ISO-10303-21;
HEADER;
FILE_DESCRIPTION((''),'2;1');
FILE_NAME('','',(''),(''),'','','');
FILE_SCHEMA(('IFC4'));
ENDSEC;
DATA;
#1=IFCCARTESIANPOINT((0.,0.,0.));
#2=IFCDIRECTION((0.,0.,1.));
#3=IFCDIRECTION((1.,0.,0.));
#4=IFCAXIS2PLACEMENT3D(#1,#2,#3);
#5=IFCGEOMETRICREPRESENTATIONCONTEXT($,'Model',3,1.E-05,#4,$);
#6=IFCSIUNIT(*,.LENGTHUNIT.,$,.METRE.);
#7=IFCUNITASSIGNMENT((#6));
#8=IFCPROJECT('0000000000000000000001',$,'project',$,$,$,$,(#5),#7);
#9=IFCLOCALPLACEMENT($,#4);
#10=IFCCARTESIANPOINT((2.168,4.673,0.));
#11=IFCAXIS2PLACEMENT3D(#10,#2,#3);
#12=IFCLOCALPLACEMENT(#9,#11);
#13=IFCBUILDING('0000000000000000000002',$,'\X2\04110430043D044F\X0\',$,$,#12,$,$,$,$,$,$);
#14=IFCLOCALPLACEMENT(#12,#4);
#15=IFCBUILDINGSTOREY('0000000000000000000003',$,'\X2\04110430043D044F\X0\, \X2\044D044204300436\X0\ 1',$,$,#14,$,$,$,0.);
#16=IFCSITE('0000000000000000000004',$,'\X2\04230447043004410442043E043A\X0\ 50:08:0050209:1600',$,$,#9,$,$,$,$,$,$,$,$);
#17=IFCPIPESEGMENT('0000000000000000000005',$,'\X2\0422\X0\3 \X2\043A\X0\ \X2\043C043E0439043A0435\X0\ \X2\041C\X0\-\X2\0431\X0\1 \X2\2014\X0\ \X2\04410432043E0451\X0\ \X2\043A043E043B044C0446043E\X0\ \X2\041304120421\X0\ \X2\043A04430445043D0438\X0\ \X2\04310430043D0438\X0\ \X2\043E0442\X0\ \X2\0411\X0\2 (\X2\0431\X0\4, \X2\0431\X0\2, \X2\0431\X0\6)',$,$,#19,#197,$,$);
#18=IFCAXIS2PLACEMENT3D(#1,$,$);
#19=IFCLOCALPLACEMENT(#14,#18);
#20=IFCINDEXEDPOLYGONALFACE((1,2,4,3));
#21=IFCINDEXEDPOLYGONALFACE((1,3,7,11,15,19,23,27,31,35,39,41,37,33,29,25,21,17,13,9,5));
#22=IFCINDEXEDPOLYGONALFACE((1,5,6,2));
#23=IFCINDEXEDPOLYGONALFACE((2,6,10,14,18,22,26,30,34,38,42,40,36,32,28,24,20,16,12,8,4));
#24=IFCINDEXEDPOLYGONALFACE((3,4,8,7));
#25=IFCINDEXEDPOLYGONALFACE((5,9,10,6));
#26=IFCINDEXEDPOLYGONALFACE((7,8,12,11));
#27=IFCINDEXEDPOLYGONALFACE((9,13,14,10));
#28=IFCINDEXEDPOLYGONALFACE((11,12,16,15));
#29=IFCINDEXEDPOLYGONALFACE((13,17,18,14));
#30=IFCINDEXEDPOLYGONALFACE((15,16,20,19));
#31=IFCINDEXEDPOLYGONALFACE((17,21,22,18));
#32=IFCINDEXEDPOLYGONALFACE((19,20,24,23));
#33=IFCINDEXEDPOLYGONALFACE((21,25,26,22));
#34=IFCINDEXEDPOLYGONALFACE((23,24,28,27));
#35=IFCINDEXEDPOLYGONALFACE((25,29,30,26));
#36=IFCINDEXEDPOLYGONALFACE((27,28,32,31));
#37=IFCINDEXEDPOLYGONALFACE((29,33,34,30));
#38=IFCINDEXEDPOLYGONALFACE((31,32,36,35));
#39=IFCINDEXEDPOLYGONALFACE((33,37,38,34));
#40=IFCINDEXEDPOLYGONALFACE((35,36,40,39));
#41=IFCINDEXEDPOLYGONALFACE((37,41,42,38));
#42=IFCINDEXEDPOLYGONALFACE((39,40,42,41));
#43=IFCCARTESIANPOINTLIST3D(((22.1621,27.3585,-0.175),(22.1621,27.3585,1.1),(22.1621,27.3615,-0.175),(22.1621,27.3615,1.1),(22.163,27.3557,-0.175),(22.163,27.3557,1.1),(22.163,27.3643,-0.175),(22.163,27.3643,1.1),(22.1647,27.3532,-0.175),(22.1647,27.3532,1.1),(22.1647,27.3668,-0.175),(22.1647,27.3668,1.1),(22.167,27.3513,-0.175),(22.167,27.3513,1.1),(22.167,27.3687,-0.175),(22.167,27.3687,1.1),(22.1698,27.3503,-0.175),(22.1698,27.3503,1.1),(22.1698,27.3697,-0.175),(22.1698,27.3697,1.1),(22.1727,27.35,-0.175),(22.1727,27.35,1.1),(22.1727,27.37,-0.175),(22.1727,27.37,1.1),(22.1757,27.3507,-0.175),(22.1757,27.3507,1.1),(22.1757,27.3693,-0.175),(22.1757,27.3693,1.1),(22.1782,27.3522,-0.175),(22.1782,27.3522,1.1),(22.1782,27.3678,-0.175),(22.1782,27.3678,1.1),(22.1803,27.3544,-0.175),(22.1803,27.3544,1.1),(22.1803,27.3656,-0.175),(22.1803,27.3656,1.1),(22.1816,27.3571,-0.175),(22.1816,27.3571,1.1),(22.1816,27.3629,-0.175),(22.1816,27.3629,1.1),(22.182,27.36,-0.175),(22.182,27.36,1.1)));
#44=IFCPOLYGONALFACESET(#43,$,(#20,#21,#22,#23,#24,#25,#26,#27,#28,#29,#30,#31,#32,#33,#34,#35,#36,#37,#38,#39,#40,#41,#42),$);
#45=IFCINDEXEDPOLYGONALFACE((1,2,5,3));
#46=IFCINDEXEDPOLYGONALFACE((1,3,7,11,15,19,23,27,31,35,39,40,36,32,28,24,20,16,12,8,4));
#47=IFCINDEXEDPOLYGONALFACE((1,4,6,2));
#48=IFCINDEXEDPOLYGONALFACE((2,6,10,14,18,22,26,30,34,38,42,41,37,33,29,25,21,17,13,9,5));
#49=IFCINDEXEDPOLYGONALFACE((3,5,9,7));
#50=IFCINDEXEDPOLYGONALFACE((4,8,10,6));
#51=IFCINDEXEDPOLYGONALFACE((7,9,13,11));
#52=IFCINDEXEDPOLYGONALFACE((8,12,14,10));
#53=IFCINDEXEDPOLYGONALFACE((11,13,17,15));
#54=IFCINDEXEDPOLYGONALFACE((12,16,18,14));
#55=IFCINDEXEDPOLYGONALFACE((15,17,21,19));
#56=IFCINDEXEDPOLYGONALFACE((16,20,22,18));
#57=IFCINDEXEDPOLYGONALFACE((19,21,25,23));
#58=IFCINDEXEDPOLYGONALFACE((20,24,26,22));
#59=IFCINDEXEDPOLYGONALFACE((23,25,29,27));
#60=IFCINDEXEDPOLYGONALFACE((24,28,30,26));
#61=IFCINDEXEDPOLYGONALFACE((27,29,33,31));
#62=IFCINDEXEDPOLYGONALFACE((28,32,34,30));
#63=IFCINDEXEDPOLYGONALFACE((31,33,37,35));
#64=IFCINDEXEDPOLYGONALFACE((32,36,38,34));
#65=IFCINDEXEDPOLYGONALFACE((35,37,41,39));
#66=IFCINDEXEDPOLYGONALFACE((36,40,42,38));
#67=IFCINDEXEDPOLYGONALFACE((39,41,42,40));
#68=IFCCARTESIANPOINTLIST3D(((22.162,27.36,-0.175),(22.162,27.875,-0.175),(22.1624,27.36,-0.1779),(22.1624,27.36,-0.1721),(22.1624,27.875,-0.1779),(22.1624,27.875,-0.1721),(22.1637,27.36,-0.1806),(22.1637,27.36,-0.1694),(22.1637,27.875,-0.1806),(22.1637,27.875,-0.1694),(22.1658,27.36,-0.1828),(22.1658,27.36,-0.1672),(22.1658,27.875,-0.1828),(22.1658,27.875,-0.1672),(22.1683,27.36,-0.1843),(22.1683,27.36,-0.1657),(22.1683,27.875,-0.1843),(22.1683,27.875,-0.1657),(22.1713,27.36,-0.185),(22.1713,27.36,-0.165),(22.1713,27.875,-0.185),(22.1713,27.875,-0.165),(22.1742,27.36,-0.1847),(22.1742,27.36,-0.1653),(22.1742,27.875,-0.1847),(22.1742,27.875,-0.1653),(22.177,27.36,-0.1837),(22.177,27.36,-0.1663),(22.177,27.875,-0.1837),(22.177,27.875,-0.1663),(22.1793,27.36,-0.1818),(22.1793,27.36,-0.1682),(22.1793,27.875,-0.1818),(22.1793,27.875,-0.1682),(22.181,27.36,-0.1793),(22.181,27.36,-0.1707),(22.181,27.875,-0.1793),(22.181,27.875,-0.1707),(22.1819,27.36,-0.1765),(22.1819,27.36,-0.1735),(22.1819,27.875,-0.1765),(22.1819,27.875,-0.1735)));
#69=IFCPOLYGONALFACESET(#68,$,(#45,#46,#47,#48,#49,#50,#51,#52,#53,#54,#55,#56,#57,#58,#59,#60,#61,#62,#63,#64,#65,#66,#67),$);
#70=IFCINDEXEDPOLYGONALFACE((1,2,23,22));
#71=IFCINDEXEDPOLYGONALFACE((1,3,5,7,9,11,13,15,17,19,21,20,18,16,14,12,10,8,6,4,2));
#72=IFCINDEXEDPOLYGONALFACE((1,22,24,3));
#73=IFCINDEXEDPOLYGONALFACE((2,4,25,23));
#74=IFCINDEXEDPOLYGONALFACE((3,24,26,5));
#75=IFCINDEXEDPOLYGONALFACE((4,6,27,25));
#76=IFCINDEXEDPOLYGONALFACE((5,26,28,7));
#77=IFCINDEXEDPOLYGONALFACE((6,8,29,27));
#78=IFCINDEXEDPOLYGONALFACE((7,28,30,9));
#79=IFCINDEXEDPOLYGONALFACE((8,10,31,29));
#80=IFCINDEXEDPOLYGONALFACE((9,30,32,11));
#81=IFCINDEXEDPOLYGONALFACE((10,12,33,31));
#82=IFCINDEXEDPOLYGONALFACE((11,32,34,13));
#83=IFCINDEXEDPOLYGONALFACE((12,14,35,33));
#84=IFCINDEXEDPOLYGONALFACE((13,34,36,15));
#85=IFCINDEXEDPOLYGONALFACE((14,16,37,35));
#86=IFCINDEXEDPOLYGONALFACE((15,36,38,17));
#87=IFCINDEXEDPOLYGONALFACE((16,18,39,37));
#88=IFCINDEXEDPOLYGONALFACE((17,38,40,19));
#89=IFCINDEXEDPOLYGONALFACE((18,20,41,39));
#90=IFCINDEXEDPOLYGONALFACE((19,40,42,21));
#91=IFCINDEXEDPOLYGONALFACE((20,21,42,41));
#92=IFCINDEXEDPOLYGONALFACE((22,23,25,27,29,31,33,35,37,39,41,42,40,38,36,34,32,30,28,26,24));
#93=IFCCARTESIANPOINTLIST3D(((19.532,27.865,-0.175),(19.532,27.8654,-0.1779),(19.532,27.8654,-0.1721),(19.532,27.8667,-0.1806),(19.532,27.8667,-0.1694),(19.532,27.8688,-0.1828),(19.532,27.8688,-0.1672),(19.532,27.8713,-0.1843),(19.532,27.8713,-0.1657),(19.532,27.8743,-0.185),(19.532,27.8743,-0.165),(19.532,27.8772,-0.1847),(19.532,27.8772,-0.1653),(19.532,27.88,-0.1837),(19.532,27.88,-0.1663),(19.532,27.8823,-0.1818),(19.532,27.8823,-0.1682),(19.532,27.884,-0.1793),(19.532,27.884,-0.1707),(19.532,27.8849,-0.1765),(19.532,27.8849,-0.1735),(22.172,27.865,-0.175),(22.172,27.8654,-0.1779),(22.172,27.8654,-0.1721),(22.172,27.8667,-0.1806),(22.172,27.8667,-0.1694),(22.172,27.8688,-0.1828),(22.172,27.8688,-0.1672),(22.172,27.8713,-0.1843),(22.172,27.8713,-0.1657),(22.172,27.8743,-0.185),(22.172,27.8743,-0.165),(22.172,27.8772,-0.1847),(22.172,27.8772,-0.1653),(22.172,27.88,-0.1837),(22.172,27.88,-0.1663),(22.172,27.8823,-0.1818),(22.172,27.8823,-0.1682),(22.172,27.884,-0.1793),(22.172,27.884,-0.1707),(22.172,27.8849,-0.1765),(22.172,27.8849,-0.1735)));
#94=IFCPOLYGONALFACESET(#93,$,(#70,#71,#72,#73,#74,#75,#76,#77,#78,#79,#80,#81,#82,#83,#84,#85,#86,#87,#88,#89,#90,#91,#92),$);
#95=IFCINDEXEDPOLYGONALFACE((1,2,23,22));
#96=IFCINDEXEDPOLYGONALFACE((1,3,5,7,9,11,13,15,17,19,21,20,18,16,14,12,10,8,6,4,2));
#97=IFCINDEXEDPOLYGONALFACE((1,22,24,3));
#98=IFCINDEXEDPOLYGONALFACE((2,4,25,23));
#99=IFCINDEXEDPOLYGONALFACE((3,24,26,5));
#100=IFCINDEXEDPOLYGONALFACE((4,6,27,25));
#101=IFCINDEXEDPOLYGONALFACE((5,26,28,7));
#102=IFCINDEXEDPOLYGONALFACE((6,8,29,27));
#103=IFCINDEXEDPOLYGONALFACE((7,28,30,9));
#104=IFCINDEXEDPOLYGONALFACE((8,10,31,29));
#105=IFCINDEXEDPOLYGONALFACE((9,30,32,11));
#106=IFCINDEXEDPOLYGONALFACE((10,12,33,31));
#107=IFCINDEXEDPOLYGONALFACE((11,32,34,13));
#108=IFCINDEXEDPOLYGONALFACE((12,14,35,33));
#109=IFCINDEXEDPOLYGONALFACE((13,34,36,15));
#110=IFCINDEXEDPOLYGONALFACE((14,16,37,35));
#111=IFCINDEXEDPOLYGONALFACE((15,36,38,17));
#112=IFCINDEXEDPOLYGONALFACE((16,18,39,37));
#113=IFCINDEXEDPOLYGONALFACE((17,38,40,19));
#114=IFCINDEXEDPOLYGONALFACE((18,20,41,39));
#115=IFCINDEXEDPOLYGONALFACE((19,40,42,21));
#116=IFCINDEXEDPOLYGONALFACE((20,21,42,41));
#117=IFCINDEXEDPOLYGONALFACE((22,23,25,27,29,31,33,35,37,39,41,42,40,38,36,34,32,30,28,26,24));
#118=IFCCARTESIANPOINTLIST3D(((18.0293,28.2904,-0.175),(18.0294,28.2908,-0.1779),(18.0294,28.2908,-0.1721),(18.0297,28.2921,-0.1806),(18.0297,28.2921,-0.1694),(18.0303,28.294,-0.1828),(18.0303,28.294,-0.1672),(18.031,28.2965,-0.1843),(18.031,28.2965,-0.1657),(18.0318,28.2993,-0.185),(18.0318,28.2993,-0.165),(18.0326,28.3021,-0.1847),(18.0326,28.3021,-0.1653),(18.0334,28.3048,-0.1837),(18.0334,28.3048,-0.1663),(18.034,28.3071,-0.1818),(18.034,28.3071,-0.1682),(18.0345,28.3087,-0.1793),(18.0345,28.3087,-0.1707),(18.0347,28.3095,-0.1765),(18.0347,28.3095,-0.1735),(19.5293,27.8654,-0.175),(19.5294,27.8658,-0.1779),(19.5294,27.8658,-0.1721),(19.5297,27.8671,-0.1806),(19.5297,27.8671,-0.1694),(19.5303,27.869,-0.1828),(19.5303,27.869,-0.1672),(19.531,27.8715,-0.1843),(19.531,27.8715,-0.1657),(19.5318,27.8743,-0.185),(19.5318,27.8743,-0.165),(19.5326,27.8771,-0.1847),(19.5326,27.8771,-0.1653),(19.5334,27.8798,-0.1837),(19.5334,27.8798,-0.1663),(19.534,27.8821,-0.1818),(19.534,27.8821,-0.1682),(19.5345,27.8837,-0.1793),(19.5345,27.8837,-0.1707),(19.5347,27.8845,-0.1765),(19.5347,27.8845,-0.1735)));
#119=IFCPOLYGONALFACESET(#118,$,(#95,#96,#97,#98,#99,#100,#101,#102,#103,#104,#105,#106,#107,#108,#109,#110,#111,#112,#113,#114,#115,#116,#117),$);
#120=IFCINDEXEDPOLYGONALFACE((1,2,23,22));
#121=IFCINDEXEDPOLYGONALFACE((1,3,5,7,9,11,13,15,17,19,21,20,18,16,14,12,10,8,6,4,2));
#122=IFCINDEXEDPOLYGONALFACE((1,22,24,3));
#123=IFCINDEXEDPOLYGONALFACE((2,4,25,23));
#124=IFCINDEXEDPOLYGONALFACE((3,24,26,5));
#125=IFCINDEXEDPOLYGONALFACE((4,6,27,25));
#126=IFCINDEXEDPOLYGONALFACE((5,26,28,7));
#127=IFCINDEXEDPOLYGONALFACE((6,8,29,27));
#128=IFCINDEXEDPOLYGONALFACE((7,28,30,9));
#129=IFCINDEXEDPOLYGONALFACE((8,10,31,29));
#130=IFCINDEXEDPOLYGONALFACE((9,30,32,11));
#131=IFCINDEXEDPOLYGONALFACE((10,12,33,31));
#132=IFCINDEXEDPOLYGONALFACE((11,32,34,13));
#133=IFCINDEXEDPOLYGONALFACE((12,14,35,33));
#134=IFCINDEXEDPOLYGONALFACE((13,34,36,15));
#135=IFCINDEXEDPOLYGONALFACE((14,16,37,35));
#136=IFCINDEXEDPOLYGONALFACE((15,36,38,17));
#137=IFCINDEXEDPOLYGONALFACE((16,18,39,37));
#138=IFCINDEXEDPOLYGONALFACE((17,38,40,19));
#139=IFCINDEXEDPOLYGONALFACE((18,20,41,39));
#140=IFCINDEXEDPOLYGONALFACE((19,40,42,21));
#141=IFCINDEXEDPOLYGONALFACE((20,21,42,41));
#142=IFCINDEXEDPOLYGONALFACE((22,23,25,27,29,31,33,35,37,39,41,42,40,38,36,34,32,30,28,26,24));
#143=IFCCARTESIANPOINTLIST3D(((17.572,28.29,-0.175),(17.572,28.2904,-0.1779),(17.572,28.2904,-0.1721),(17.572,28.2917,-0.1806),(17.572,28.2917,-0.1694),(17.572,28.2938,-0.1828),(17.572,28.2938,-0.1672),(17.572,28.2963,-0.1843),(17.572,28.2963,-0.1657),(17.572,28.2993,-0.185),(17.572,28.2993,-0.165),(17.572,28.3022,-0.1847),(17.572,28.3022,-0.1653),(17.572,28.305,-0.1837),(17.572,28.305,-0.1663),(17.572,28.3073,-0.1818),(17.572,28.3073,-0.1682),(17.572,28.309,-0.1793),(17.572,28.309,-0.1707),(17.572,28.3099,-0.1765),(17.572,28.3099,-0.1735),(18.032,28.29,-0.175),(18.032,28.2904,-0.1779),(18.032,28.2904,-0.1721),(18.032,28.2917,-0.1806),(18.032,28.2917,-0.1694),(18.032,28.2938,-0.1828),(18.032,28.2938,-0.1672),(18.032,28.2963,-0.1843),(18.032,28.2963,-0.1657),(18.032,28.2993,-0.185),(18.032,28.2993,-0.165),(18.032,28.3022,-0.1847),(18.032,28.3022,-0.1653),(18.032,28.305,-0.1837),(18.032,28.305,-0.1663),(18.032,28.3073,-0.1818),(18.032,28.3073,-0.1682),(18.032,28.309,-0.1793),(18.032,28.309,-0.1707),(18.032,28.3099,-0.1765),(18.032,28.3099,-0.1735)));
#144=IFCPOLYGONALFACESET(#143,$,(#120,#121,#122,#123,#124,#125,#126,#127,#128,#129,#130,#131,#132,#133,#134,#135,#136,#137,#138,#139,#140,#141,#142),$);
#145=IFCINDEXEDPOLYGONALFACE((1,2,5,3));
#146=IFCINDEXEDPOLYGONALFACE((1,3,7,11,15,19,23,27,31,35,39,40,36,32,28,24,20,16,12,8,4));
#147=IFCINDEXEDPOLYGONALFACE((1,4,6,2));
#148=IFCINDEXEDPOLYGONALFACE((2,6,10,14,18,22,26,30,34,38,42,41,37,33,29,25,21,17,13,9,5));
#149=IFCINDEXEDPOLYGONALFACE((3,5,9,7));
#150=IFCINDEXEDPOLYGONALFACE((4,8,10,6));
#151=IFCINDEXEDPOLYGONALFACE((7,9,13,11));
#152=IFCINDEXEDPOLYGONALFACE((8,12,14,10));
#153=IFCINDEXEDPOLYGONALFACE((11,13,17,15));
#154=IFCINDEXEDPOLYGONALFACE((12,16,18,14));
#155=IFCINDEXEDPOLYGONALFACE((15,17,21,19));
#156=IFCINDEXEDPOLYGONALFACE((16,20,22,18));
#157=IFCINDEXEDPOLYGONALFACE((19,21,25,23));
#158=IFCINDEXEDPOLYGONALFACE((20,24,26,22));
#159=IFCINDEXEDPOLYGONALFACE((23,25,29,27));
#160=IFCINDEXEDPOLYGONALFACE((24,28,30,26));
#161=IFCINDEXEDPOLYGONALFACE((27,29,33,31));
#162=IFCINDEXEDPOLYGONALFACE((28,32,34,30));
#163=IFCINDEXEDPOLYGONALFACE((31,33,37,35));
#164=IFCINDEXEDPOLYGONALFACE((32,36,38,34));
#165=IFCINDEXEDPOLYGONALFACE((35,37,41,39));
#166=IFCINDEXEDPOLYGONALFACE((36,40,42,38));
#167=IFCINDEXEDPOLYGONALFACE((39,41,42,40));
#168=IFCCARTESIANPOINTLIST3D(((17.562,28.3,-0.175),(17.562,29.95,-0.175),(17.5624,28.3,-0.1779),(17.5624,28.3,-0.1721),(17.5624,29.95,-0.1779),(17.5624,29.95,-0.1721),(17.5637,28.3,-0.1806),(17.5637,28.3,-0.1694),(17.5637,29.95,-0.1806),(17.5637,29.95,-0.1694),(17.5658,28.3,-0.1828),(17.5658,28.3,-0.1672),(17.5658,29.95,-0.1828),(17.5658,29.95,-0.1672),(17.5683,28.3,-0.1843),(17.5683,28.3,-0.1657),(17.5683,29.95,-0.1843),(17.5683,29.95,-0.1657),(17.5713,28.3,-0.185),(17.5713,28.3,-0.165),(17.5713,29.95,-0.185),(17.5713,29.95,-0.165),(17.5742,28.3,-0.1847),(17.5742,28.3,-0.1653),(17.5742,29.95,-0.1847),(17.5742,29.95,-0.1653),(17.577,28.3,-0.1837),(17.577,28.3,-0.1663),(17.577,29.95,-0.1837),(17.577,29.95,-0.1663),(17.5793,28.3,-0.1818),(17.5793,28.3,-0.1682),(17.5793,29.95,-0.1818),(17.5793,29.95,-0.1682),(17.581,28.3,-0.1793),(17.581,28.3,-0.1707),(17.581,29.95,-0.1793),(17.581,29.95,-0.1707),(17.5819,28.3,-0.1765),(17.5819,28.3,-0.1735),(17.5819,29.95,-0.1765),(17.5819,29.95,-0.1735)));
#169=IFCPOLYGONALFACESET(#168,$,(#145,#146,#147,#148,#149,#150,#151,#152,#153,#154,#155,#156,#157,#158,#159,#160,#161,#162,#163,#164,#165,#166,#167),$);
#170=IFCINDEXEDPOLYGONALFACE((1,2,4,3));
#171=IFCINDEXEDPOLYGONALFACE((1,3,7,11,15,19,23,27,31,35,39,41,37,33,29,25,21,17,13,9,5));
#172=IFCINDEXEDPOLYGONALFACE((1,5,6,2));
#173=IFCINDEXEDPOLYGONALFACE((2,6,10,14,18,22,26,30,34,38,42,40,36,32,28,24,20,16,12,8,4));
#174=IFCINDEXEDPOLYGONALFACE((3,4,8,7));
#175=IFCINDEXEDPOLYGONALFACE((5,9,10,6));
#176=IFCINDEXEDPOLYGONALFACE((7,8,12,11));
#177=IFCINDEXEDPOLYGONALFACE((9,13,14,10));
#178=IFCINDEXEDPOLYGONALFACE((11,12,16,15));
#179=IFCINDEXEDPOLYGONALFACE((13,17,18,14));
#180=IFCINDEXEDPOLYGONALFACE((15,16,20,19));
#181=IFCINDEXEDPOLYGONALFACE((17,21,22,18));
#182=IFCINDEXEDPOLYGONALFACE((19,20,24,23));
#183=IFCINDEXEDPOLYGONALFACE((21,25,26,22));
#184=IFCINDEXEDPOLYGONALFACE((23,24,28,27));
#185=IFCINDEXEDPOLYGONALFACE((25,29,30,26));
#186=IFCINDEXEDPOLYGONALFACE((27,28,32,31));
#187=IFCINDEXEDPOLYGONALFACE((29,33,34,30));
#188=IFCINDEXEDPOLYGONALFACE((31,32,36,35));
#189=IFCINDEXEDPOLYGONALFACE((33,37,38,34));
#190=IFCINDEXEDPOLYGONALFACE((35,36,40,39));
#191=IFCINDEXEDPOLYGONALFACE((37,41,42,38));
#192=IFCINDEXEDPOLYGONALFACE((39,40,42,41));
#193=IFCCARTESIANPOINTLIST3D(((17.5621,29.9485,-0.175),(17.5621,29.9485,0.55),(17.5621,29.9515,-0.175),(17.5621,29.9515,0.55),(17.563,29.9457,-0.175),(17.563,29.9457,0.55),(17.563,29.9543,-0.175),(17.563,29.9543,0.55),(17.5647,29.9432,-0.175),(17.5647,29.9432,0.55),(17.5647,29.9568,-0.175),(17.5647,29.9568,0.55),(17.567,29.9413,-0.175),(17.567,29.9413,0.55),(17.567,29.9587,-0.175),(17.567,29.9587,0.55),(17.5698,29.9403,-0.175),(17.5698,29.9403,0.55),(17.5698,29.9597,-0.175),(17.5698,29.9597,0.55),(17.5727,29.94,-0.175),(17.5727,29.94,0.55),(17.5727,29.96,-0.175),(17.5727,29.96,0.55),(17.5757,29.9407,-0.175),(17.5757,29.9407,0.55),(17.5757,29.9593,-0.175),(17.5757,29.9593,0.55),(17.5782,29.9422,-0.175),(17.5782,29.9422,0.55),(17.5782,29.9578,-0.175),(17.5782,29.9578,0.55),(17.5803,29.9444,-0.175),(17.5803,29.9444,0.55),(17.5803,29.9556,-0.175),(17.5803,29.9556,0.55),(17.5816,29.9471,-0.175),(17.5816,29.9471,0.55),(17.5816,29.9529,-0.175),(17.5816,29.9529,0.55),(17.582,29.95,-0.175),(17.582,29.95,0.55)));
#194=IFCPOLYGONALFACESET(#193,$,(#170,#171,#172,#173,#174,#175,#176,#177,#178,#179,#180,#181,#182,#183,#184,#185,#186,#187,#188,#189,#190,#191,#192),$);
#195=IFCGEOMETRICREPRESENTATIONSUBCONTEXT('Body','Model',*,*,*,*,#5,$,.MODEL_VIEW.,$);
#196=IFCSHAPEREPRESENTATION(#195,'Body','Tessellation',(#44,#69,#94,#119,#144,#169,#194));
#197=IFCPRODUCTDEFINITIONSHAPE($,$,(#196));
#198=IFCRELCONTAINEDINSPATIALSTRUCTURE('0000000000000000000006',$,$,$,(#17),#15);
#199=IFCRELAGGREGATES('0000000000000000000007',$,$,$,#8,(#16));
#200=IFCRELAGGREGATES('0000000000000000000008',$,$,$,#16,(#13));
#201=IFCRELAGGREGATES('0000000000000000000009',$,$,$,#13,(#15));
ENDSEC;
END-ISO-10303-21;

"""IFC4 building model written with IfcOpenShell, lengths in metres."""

from ifc_helpers import new_model, si_unit, frame, origin_with_axes, origin_2d, place, context, subcontext, project, spatial, circle, extrude, element, save


model = new_model("IFC4")

# Units and contexts
model_context = context("Model", 3, precision=1e-05, world=origin_with_axes())
body_context = subcontext(model_context, "Body", "Model", "MODEL_VIEW")
ifc_project = project(units=[si_unit("LENGTHUNIT", "METRE")], contexts=[model_context])

# Site, building, storey
site_placement = place(None, origin_with_axes())
site = spatial("IfcSite", under=ifc_project, at=site_placement, Name="Участок 50:08:0050209:1600")
building_placement = place(site_placement, frame((2.168, 4.673, 0.0), z_axis=(0.0, 0.0, 1.0), x_axis=(1.0, 0.0, 0.0)))
building = spatial("IfcBuilding", under=site, at=building_placement, Name="Баня")
storey_placement = place(building_placement, origin_with_axes())
storey = spatial("IfcBuildingStorey", under=building, at=storey_placement, Name="Баня, этаж 1", Elevation=0.0)

# Pipe segment
pipe_segment_1_placement = place(storey_placement, origin_with_axes())
element("IfcPipeSegment", 1, at=pipe_segment_1_placement, inside=storey, Name="Т3 к мойке М-б1 — своё кольцо ГВС кухни бани от Б2 (б4, б2, б6)", context=body_context, shape_type="SweptSolid", body=[
    extrude(circle(Radius=0.01, at=origin_2d()), frame((22.172, 27.36, 1.1), z_axis=(0.0, 0.0, -1.0), x_axis=(1.0, 0.0, 0.0)), (0.0, 0.0, 1.0), 1.275),
    extrude(circle(Radius=0.01, at=origin_2d()), frame((22.172, 27.36, -0.175), z_axis=(0.0, 1.0, 0.0), x_axis=(-1.0, 0.0, 0.0)), (0.0, 0.0, 1.0), 0.515),
    extrude(circle(Radius=0.01, at=origin_2d()), frame((22.172, 27.875, -0.175), z_axis=(-1.0, 0.0, 0.0), x_axis=(0.0, -1.0, 0.0)), (0.0, 0.0, 1.0), 2.64),
    extrude(circle(Radius=0.01, at=origin_2d()), frame((19.532, 27.875, -0.175), z_axis=(-0.962127, 0.272603, 0.0), x_axis=(-0.272603, -0.962127, 0.0)), (0.0, 0.0, 1.0), 1.559),
    extrude(circle(Radius=0.01, at=origin_2d()), frame((18.032, 28.3, -0.175), z_axis=(-1.0, 0.0, 0.0), x_axis=(0.0, -1.0, 0.0)), (0.0, 0.0, 1.0), 0.46),
    extrude(circle(Radius=0.01, at=origin_2d()), frame((17.572, 28.3, -0.175), z_axis=(0.0, 1.0, 0.0), x_axis=(-1.0, 0.0, 0.0)), (0.0, 0.0, 1.0), 1.65),
    extrude(circle(Radius=0.01, at=origin_2d()), frame((17.572, 29.95, -0.175), z_axis=(0.0, 0.0, 1.0), x_axis=(1.0, 0.0, 0.0)), (0.0, 0.0, 1.0), 0.725),
])

save(model, "model.ifc")
